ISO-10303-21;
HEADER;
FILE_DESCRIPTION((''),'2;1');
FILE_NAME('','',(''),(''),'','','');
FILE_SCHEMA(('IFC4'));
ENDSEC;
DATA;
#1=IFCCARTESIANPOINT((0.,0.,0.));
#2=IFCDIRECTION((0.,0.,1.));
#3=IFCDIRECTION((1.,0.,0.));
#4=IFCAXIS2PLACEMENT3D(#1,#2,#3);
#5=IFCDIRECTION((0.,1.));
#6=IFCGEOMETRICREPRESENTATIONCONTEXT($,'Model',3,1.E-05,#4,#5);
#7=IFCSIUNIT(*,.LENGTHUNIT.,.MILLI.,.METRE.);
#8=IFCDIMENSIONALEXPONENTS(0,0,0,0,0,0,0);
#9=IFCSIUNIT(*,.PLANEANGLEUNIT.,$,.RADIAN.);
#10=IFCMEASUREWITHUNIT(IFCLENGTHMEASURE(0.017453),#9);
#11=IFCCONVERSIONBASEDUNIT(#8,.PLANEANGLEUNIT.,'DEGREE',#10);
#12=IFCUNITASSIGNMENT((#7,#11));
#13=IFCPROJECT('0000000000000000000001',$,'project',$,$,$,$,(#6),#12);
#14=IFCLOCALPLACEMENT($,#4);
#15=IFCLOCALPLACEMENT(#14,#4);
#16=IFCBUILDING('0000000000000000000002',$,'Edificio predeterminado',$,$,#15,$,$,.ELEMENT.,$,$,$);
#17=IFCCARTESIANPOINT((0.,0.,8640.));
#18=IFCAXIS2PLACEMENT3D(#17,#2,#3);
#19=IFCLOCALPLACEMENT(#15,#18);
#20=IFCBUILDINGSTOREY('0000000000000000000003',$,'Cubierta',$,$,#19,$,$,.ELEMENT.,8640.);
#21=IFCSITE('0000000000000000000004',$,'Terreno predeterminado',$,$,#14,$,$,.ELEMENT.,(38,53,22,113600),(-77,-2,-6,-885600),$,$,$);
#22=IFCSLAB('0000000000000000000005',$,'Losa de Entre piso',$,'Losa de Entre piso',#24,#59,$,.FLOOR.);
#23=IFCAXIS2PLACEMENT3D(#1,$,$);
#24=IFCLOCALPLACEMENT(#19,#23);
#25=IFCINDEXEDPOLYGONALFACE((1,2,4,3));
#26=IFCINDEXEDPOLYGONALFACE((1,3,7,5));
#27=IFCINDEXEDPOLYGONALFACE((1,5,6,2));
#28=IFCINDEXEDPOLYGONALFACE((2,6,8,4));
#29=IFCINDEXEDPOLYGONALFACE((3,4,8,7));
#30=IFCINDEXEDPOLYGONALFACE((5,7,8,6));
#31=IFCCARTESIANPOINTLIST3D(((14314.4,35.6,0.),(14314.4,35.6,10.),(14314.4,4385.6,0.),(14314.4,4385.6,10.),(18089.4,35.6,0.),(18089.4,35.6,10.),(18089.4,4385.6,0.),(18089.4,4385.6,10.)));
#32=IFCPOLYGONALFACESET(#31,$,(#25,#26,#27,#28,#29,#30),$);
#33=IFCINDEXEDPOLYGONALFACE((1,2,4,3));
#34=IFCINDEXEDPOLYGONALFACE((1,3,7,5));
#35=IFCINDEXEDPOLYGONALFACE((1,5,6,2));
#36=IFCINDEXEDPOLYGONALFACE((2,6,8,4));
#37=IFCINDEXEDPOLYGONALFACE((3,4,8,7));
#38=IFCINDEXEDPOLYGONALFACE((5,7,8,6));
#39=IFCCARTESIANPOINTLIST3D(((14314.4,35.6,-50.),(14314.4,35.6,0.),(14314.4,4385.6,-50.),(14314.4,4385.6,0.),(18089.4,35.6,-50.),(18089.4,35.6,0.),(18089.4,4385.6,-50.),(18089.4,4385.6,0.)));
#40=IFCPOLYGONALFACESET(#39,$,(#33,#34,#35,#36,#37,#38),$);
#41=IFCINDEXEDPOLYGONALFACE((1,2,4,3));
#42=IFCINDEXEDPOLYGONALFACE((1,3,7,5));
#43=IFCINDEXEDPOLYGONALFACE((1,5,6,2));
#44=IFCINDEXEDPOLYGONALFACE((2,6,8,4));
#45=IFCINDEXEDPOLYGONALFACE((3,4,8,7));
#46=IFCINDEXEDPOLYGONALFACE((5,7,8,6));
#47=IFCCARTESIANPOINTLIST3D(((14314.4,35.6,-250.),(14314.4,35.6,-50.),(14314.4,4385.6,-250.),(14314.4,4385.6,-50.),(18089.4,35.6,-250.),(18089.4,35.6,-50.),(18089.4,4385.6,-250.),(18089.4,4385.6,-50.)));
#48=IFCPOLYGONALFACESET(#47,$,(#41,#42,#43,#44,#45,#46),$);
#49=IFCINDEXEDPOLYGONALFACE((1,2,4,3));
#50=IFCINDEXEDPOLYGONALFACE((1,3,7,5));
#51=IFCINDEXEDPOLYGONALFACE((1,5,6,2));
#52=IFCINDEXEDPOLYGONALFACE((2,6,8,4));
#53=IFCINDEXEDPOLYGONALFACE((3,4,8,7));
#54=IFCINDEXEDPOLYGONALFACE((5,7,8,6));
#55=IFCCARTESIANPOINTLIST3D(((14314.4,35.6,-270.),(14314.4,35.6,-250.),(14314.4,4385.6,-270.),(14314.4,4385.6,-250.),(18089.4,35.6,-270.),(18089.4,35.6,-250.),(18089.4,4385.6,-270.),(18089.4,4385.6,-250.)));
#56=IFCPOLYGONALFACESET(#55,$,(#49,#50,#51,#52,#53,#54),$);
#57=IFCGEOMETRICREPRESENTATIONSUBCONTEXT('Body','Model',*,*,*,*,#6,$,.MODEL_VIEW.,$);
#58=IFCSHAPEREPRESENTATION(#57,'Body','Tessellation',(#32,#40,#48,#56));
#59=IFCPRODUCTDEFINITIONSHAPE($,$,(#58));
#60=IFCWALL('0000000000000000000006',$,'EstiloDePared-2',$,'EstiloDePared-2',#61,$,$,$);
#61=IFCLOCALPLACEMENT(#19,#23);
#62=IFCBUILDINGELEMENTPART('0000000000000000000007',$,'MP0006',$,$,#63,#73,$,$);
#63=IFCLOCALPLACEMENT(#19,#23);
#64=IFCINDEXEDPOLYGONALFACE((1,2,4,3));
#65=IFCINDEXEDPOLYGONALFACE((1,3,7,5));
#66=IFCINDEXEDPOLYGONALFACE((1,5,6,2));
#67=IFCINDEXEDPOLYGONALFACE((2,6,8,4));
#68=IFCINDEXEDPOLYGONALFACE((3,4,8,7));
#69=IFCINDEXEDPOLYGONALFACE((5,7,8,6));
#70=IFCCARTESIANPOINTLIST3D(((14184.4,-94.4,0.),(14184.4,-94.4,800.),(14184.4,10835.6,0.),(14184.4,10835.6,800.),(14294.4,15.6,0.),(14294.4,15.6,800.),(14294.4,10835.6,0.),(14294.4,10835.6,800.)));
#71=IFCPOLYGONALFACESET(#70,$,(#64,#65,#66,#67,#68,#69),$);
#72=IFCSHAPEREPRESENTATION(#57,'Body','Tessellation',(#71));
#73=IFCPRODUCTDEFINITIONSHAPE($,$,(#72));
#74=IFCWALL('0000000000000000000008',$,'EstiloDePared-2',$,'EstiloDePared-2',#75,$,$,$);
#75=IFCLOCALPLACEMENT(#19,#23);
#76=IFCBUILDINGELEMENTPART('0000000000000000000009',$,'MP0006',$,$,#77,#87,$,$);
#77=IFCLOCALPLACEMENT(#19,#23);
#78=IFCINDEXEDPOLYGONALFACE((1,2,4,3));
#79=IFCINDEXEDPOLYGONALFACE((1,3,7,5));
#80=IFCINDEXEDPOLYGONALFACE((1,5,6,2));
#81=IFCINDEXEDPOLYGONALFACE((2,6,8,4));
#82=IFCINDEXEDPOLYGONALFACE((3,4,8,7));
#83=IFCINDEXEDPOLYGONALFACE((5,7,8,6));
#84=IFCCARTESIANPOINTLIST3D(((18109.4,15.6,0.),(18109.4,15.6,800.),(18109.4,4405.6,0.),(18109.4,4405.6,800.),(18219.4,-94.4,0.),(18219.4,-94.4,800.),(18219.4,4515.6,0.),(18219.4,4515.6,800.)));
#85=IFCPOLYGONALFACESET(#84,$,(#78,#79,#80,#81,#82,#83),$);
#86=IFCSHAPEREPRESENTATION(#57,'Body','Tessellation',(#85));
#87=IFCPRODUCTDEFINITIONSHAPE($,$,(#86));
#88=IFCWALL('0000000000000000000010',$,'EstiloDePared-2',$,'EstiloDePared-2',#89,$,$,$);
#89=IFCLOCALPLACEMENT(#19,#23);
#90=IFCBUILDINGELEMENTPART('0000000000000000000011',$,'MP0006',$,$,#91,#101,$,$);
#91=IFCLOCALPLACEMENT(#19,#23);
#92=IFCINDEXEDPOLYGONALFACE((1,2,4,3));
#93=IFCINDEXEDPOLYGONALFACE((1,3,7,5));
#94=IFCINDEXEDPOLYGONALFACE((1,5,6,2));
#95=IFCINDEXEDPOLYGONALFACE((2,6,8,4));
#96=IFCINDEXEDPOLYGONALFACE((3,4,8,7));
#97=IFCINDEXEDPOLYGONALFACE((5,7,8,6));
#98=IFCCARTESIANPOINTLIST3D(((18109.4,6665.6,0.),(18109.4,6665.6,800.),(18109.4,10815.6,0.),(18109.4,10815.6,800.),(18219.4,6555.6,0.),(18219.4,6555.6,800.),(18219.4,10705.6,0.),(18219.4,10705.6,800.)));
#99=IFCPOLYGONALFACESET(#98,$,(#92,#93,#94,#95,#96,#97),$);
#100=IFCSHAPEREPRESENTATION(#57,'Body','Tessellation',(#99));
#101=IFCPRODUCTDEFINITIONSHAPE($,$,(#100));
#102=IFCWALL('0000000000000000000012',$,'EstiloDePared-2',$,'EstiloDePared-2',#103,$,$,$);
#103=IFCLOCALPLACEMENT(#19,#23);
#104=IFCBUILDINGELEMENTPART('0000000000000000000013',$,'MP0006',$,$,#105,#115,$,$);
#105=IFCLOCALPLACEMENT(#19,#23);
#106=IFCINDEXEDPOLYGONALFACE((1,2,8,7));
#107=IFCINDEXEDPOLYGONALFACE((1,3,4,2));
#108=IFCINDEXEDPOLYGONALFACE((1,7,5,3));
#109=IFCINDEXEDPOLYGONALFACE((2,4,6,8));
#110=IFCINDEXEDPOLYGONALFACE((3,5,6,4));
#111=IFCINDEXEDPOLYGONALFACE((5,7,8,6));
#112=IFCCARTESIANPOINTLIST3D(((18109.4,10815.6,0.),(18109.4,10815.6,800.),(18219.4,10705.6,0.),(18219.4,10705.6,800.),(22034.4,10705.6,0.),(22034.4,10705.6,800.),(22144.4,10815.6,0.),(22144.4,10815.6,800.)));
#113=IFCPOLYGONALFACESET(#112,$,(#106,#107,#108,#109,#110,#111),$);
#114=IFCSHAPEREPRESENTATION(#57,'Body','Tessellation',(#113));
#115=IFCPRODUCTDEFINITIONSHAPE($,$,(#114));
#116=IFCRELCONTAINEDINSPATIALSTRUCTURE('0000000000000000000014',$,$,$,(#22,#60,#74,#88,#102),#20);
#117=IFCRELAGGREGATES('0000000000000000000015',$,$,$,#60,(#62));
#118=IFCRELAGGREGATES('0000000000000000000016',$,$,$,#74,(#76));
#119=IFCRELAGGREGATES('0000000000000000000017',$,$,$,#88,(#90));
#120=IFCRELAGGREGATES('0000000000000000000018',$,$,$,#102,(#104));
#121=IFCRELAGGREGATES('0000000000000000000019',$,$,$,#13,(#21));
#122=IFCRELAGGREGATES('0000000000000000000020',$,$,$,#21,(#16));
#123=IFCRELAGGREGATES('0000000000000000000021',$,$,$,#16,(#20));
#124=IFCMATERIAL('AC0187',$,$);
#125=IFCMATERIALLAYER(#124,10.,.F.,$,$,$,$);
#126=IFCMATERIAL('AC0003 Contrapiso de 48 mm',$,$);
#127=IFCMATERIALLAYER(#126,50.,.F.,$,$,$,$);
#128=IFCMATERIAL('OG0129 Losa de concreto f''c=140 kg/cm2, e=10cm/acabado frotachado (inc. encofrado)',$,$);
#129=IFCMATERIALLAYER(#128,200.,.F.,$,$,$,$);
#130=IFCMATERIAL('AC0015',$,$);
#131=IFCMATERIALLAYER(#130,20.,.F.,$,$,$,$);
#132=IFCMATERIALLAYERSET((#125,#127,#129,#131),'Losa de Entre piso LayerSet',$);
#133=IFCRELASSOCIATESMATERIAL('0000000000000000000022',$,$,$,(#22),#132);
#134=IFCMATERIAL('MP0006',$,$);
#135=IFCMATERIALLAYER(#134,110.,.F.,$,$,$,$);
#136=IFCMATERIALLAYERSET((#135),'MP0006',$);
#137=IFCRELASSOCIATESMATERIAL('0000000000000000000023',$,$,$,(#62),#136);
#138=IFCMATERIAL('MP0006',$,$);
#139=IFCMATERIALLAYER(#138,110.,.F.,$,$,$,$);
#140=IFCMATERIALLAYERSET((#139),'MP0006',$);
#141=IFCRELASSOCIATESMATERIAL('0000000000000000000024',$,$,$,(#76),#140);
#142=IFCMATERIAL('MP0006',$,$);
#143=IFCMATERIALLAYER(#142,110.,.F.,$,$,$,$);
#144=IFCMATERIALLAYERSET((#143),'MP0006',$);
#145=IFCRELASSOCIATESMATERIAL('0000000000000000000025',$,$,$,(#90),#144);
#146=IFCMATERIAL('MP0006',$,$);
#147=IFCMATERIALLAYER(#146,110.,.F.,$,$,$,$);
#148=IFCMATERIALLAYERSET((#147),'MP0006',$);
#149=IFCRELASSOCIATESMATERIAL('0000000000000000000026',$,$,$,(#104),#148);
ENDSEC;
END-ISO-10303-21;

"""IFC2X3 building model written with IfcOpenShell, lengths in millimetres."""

from ifc_helpers import new_model, entity, si_unit, converted_unit, direction, frame, origin_with_axes, place, context, subcontext, project, spatial, polyline, outline, extrude, material, layer, layer_set, layer_usage, element, aggregate, save


model = new_model("IFC2X3")

# Units and contexts
model_context = context("Model", 3, precision=1e-05, world=origin_with_axes(), true_north=direction((0.0, 1.0)))
body_context = subcontext(model_context, "Body", "Model", "MODEL_VIEW")
ifc_project = project(units=[si_unit("LENGTHUNIT", "METRE", prefix="MILLI"), converted_unit("PLANEANGLEUNIT", "DEGREE", entity("IfcLengthMeasure", 0.017453), si_unit("PLANEANGLEUNIT", "RADIAN"), dimensions=[0, 0, 0, 0, 0, 0, 0])], contexts=[model_context])

# Site, building, storey
site_placement = place(None, origin_with_axes())
site = spatial("IfcSite", under=ifc_project, at=site_placement, Name="Terreno predeterminado", CompositionType="ELEMENT", RefLatitude=(38, 53, 22, 113600), RefLongitude=(-77, -2, -6, -885600))
building_placement = place(site_placement, origin_with_axes())
building = spatial("IfcBuilding", under=site, at=building_placement, Name="Edificio predeterminado", CompositionType="ELEMENT")
storey_placement = place(building_placement, frame((0.0, 0.0, 8640.0), z_axis=(0.0, 0.0, 1.0), x_axis=(1.0, 0.0, 0.0)))
storey = spatial("IfcBuildingStorey", under=building, at=storey_placement, Name="Cubierta", CompositionType="ELEMENT", Elevation=8640.0)

# Slab
ifc_material_1 = material(Name="AC0187")
ifc_layer_1 = layer(ifc_material_1, 10.0, ventilated=False)
ifc_material_2 = material(Name="AC0003 Contrapiso de 48 mm")
ifc_layer_2 = layer(ifc_material_2, 50.0, ventilated=False)
ifc_material_3 = material(Name="OG0129 Losa de concreto f'c=140 kg/cm2, e=10cm/acabado frotachado (inc. encofrado)")
ifc_layer_3 = layer(ifc_material_3, 200.0, ventilated=False)
ifc_material_4 = material(Name="AC0015")
ifc_layer_4 = layer(ifc_material_4, 20.0, ventilated=False)
ifc_layer_set_1 = layer_set([ifc_layer_1, ifc_layer_2, ifc_layer_3, ifc_layer_4], Name="Losa de Entre piso LayerSet")
ifc_layer_usage_1 = layer_usage(ifc_layer_set_1, "AXIS3", "NEGATIVE", 0.0)
slab_1_placement = place(storey_placement, frame((0.0, 0.0, -8640.0), z_axis=(0.0, 0.0, 1.0), x_axis=(1.0, 0.0, 0.0)))
element("IfcSlab", 1, at=slab_1_placement, inside=storey, material=ifc_layer_usage_1, Name="Losa de Entre piso", ObjectType="Losa de Entre piso", PredefinedType="FLOOR", context=body_context, shape_type="SweptSolid", body=[
    extrude(outline(polyline([(0.0, 4350.0), (3775.0, 4350.0), (3775.0, 0.0), (0.0, 0.0), (0.0, 4350.0)])), frame((18089.4, 35.6, 8640.0), z_axis=(0.0, 0.0, -1.0), x_axis=(-1.0, 0.0, 0.0)), (0.0, 0.0, -1.0), 10.0),
    extrude(outline(polyline([(0.0, 4350.0), (3775.0, 4350.0), (3775.0, 0.0), (0.0, 0.0), (0.0, 4350.0)])), frame((18089.4, 35.6, 8590.0), z_axis=(0.0, 0.0, -1.0), x_axis=(-1.0, 0.0, 0.0)), (0.0, 0.0, -1.0), 50.0),
    extrude(outline(polyline([(0.0, 4350.0), (3775.0, 4350.0), (3775.0, 0.0), (0.0, 0.0), (0.0, 4350.0)])), frame((18089.4, 35.6, 8390.0), z_axis=(0.0, 0.0, -1.0), x_axis=(-1.0, 0.0, 0.0)), (0.0, 0.0, -1.0), 200.0),
    extrude(outline(polyline([(0.0, 4350.0), (3775.0, 4350.0), (3775.0, 0.0), (0.0, 0.0), (0.0, 4350.0)])), frame((18089.4, 35.6, 8370.0), z_axis=(0.0, 0.0, -1.0), x_axis=(-1.0, 0.0, 0.0)), (0.0, 0.0, -1.0), 20.0),
])

# Walls, building element parts
wall_1_placement = place(storey_placement, frame((14239.4, -39.4, 0.0), z_axis=(0.0, 0.0, 1.0), x_axis=(0.0, 1.0, 0.0)))
wall_1 = element("IfcWall", 2, at=wall_1_placement, inside=storey, Name="EstiloDePared-2", ObjectType="EstiloDePared-2")
ifc_material_5 = material(Name="MP0006")
ifc_layer_5 = layer(ifc_material_5, 110.0, ventilated=False)
ifc_layer_set_2 = layer_set([ifc_layer_5], Name="MP0006")
ifc_layer_usage_2 = layer_usage(ifc_layer_set_2, "AXIS2", "NEGATIVE", -55.0)
building_element_part_1_placement = place(wall_1_placement, origin_with_axes())
building_element_part_1 = element("IfcBuildingElementPart", 3, at=building_element_part_1_placement, material=ifc_layer_usage_2, Name="MP0006", context=body_context, shape_type="SweptSolid", body=[
    extrude(outline(polyline([(10875.0, 55.0), (10875.0, -55.0), (55.0, -55.0), (-55.0, 55.0), (10875.0, 55.0)])), origin_with_axes(), (0.0, 0.0, 1.0), 800.0),
])
aggregate(wall_1, [building_element_part_1])
wall_2_placement = place(storey_placement, frame((18164.4, -39.4, 0.0), z_axis=(0.0, 0.0, 1.0), x_axis=(0.0, 1.0, 0.0)))
wall_2 = element("IfcWall", 4, at=wall_2_placement, inside=storey, Name="EstiloDePared-2", ObjectType="EstiloDePared-2")
ifc_material_6 = material(Name="MP0006")
ifc_layer_6 = layer(ifc_material_6, 110.0, ventilated=False)
ifc_layer_set_3 = layer_set([ifc_layer_6], Name="MP0006")
ifc_layer_usage_3 = layer_usage(ifc_layer_set_3, "AXIS2", "NEGATIVE", -55.0)
building_element_part_2_placement = place(wall_2_placement, origin_with_axes())
building_element_part_2 = element("IfcBuildingElementPart", 5, at=building_element_part_2_placement, material=ifc_layer_usage_3, Name="MP0006", context=body_context, shape_type="SweptSolid", body=[
    extrude(outline(polyline([(4445.0, 55.0), (4555.0, -55.0), (-55.0, -55.0), (55.0, 55.0), (4445.0, 55.0)])), origin_with_axes(), (0.0, 0.0, 1.0), 800.0),
])
aggregate(wall_2, [building_element_part_2])
wall_3_placement = place(storey_placement, frame((18164.4, 6610.6, 0.0), z_axis=(0.0, 0.0, 1.0), x_axis=(0.0, 1.0, 0.0)))
wall_3 = element("IfcWall", 6, at=wall_3_placement, inside=storey, Name="EstiloDePared-2", ObjectType="EstiloDePared-2")
ifc_material_7 = material(Name="MP0006")
ifc_layer_7 = layer(ifc_material_7, 110.0, ventilated=False)
ifc_layer_set_4 = layer_set([ifc_layer_7], Name="MP0006")
ifc_layer_usage_4 = layer_usage(ifc_layer_set_4, "AXIS2", "NEGATIVE", -55.0)
building_element_part_3_placement = place(wall_3_placement, origin_with_axes())
building_element_part_3 = element("IfcBuildingElementPart", 7, at=building_element_part_3_placement, material=ifc_layer_usage_4, Name="MP0006", context=body_context, shape_type="SweptSolid", body=[
    extrude(outline(polyline([(4205.0, 55.0), (4095.0, -55.0), (-55.0, -55.0), (55.0, 55.0), (4205.0, 55.0)])), origin_with_axes(), (0.0, 0.0, 1.0), 800.0),
])
aggregate(wall_3, [building_element_part_3])
wall_4_placement = place(storey_placement, frame((18164.4, 10760.6, 0.0), z_axis=(0.0, 0.0, 1.0), x_axis=(1.0, 0.0, 0.0)))
wall_4 = element("IfcWall", 8, at=wall_4_placement, inside=storey, Name="EstiloDePared-2", ObjectType="EstiloDePared-2")
ifc_material_8 = material(Name="MP0006")
ifc_layer_8 = layer(ifc_material_8, 110.0, ventilated=False)
ifc_layer_set_5 = layer_set([ifc_layer_8], Name="MP0006")
ifc_layer_usage_5 = layer_usage(ifc_layer_set_5, "AXIS2", "NEGATIVE", -55.0)
building_element_part_4_placement = place(wall_4_placement, origin_with_axes())
building_element_part_4 = element("IfcBuildingElementPart", 9, at=building_element_part_4_placement, material=ifc_layer_usage_5, Name="MP0006", context=body_context, shape_type="SweptSolid", body=[
    extrude(outline(polyline([(3980.0, 55.0), (3870.0, -55.0), (55.0, -55.0), (-55.0, 55.0), (3980.0, 55.0)])), origin_with_axes(), (0.0, 0.0, 1.0), 800.0),
])
aggregate(wall_4, [building_element_part_4])

save(model, "model.ifc")
